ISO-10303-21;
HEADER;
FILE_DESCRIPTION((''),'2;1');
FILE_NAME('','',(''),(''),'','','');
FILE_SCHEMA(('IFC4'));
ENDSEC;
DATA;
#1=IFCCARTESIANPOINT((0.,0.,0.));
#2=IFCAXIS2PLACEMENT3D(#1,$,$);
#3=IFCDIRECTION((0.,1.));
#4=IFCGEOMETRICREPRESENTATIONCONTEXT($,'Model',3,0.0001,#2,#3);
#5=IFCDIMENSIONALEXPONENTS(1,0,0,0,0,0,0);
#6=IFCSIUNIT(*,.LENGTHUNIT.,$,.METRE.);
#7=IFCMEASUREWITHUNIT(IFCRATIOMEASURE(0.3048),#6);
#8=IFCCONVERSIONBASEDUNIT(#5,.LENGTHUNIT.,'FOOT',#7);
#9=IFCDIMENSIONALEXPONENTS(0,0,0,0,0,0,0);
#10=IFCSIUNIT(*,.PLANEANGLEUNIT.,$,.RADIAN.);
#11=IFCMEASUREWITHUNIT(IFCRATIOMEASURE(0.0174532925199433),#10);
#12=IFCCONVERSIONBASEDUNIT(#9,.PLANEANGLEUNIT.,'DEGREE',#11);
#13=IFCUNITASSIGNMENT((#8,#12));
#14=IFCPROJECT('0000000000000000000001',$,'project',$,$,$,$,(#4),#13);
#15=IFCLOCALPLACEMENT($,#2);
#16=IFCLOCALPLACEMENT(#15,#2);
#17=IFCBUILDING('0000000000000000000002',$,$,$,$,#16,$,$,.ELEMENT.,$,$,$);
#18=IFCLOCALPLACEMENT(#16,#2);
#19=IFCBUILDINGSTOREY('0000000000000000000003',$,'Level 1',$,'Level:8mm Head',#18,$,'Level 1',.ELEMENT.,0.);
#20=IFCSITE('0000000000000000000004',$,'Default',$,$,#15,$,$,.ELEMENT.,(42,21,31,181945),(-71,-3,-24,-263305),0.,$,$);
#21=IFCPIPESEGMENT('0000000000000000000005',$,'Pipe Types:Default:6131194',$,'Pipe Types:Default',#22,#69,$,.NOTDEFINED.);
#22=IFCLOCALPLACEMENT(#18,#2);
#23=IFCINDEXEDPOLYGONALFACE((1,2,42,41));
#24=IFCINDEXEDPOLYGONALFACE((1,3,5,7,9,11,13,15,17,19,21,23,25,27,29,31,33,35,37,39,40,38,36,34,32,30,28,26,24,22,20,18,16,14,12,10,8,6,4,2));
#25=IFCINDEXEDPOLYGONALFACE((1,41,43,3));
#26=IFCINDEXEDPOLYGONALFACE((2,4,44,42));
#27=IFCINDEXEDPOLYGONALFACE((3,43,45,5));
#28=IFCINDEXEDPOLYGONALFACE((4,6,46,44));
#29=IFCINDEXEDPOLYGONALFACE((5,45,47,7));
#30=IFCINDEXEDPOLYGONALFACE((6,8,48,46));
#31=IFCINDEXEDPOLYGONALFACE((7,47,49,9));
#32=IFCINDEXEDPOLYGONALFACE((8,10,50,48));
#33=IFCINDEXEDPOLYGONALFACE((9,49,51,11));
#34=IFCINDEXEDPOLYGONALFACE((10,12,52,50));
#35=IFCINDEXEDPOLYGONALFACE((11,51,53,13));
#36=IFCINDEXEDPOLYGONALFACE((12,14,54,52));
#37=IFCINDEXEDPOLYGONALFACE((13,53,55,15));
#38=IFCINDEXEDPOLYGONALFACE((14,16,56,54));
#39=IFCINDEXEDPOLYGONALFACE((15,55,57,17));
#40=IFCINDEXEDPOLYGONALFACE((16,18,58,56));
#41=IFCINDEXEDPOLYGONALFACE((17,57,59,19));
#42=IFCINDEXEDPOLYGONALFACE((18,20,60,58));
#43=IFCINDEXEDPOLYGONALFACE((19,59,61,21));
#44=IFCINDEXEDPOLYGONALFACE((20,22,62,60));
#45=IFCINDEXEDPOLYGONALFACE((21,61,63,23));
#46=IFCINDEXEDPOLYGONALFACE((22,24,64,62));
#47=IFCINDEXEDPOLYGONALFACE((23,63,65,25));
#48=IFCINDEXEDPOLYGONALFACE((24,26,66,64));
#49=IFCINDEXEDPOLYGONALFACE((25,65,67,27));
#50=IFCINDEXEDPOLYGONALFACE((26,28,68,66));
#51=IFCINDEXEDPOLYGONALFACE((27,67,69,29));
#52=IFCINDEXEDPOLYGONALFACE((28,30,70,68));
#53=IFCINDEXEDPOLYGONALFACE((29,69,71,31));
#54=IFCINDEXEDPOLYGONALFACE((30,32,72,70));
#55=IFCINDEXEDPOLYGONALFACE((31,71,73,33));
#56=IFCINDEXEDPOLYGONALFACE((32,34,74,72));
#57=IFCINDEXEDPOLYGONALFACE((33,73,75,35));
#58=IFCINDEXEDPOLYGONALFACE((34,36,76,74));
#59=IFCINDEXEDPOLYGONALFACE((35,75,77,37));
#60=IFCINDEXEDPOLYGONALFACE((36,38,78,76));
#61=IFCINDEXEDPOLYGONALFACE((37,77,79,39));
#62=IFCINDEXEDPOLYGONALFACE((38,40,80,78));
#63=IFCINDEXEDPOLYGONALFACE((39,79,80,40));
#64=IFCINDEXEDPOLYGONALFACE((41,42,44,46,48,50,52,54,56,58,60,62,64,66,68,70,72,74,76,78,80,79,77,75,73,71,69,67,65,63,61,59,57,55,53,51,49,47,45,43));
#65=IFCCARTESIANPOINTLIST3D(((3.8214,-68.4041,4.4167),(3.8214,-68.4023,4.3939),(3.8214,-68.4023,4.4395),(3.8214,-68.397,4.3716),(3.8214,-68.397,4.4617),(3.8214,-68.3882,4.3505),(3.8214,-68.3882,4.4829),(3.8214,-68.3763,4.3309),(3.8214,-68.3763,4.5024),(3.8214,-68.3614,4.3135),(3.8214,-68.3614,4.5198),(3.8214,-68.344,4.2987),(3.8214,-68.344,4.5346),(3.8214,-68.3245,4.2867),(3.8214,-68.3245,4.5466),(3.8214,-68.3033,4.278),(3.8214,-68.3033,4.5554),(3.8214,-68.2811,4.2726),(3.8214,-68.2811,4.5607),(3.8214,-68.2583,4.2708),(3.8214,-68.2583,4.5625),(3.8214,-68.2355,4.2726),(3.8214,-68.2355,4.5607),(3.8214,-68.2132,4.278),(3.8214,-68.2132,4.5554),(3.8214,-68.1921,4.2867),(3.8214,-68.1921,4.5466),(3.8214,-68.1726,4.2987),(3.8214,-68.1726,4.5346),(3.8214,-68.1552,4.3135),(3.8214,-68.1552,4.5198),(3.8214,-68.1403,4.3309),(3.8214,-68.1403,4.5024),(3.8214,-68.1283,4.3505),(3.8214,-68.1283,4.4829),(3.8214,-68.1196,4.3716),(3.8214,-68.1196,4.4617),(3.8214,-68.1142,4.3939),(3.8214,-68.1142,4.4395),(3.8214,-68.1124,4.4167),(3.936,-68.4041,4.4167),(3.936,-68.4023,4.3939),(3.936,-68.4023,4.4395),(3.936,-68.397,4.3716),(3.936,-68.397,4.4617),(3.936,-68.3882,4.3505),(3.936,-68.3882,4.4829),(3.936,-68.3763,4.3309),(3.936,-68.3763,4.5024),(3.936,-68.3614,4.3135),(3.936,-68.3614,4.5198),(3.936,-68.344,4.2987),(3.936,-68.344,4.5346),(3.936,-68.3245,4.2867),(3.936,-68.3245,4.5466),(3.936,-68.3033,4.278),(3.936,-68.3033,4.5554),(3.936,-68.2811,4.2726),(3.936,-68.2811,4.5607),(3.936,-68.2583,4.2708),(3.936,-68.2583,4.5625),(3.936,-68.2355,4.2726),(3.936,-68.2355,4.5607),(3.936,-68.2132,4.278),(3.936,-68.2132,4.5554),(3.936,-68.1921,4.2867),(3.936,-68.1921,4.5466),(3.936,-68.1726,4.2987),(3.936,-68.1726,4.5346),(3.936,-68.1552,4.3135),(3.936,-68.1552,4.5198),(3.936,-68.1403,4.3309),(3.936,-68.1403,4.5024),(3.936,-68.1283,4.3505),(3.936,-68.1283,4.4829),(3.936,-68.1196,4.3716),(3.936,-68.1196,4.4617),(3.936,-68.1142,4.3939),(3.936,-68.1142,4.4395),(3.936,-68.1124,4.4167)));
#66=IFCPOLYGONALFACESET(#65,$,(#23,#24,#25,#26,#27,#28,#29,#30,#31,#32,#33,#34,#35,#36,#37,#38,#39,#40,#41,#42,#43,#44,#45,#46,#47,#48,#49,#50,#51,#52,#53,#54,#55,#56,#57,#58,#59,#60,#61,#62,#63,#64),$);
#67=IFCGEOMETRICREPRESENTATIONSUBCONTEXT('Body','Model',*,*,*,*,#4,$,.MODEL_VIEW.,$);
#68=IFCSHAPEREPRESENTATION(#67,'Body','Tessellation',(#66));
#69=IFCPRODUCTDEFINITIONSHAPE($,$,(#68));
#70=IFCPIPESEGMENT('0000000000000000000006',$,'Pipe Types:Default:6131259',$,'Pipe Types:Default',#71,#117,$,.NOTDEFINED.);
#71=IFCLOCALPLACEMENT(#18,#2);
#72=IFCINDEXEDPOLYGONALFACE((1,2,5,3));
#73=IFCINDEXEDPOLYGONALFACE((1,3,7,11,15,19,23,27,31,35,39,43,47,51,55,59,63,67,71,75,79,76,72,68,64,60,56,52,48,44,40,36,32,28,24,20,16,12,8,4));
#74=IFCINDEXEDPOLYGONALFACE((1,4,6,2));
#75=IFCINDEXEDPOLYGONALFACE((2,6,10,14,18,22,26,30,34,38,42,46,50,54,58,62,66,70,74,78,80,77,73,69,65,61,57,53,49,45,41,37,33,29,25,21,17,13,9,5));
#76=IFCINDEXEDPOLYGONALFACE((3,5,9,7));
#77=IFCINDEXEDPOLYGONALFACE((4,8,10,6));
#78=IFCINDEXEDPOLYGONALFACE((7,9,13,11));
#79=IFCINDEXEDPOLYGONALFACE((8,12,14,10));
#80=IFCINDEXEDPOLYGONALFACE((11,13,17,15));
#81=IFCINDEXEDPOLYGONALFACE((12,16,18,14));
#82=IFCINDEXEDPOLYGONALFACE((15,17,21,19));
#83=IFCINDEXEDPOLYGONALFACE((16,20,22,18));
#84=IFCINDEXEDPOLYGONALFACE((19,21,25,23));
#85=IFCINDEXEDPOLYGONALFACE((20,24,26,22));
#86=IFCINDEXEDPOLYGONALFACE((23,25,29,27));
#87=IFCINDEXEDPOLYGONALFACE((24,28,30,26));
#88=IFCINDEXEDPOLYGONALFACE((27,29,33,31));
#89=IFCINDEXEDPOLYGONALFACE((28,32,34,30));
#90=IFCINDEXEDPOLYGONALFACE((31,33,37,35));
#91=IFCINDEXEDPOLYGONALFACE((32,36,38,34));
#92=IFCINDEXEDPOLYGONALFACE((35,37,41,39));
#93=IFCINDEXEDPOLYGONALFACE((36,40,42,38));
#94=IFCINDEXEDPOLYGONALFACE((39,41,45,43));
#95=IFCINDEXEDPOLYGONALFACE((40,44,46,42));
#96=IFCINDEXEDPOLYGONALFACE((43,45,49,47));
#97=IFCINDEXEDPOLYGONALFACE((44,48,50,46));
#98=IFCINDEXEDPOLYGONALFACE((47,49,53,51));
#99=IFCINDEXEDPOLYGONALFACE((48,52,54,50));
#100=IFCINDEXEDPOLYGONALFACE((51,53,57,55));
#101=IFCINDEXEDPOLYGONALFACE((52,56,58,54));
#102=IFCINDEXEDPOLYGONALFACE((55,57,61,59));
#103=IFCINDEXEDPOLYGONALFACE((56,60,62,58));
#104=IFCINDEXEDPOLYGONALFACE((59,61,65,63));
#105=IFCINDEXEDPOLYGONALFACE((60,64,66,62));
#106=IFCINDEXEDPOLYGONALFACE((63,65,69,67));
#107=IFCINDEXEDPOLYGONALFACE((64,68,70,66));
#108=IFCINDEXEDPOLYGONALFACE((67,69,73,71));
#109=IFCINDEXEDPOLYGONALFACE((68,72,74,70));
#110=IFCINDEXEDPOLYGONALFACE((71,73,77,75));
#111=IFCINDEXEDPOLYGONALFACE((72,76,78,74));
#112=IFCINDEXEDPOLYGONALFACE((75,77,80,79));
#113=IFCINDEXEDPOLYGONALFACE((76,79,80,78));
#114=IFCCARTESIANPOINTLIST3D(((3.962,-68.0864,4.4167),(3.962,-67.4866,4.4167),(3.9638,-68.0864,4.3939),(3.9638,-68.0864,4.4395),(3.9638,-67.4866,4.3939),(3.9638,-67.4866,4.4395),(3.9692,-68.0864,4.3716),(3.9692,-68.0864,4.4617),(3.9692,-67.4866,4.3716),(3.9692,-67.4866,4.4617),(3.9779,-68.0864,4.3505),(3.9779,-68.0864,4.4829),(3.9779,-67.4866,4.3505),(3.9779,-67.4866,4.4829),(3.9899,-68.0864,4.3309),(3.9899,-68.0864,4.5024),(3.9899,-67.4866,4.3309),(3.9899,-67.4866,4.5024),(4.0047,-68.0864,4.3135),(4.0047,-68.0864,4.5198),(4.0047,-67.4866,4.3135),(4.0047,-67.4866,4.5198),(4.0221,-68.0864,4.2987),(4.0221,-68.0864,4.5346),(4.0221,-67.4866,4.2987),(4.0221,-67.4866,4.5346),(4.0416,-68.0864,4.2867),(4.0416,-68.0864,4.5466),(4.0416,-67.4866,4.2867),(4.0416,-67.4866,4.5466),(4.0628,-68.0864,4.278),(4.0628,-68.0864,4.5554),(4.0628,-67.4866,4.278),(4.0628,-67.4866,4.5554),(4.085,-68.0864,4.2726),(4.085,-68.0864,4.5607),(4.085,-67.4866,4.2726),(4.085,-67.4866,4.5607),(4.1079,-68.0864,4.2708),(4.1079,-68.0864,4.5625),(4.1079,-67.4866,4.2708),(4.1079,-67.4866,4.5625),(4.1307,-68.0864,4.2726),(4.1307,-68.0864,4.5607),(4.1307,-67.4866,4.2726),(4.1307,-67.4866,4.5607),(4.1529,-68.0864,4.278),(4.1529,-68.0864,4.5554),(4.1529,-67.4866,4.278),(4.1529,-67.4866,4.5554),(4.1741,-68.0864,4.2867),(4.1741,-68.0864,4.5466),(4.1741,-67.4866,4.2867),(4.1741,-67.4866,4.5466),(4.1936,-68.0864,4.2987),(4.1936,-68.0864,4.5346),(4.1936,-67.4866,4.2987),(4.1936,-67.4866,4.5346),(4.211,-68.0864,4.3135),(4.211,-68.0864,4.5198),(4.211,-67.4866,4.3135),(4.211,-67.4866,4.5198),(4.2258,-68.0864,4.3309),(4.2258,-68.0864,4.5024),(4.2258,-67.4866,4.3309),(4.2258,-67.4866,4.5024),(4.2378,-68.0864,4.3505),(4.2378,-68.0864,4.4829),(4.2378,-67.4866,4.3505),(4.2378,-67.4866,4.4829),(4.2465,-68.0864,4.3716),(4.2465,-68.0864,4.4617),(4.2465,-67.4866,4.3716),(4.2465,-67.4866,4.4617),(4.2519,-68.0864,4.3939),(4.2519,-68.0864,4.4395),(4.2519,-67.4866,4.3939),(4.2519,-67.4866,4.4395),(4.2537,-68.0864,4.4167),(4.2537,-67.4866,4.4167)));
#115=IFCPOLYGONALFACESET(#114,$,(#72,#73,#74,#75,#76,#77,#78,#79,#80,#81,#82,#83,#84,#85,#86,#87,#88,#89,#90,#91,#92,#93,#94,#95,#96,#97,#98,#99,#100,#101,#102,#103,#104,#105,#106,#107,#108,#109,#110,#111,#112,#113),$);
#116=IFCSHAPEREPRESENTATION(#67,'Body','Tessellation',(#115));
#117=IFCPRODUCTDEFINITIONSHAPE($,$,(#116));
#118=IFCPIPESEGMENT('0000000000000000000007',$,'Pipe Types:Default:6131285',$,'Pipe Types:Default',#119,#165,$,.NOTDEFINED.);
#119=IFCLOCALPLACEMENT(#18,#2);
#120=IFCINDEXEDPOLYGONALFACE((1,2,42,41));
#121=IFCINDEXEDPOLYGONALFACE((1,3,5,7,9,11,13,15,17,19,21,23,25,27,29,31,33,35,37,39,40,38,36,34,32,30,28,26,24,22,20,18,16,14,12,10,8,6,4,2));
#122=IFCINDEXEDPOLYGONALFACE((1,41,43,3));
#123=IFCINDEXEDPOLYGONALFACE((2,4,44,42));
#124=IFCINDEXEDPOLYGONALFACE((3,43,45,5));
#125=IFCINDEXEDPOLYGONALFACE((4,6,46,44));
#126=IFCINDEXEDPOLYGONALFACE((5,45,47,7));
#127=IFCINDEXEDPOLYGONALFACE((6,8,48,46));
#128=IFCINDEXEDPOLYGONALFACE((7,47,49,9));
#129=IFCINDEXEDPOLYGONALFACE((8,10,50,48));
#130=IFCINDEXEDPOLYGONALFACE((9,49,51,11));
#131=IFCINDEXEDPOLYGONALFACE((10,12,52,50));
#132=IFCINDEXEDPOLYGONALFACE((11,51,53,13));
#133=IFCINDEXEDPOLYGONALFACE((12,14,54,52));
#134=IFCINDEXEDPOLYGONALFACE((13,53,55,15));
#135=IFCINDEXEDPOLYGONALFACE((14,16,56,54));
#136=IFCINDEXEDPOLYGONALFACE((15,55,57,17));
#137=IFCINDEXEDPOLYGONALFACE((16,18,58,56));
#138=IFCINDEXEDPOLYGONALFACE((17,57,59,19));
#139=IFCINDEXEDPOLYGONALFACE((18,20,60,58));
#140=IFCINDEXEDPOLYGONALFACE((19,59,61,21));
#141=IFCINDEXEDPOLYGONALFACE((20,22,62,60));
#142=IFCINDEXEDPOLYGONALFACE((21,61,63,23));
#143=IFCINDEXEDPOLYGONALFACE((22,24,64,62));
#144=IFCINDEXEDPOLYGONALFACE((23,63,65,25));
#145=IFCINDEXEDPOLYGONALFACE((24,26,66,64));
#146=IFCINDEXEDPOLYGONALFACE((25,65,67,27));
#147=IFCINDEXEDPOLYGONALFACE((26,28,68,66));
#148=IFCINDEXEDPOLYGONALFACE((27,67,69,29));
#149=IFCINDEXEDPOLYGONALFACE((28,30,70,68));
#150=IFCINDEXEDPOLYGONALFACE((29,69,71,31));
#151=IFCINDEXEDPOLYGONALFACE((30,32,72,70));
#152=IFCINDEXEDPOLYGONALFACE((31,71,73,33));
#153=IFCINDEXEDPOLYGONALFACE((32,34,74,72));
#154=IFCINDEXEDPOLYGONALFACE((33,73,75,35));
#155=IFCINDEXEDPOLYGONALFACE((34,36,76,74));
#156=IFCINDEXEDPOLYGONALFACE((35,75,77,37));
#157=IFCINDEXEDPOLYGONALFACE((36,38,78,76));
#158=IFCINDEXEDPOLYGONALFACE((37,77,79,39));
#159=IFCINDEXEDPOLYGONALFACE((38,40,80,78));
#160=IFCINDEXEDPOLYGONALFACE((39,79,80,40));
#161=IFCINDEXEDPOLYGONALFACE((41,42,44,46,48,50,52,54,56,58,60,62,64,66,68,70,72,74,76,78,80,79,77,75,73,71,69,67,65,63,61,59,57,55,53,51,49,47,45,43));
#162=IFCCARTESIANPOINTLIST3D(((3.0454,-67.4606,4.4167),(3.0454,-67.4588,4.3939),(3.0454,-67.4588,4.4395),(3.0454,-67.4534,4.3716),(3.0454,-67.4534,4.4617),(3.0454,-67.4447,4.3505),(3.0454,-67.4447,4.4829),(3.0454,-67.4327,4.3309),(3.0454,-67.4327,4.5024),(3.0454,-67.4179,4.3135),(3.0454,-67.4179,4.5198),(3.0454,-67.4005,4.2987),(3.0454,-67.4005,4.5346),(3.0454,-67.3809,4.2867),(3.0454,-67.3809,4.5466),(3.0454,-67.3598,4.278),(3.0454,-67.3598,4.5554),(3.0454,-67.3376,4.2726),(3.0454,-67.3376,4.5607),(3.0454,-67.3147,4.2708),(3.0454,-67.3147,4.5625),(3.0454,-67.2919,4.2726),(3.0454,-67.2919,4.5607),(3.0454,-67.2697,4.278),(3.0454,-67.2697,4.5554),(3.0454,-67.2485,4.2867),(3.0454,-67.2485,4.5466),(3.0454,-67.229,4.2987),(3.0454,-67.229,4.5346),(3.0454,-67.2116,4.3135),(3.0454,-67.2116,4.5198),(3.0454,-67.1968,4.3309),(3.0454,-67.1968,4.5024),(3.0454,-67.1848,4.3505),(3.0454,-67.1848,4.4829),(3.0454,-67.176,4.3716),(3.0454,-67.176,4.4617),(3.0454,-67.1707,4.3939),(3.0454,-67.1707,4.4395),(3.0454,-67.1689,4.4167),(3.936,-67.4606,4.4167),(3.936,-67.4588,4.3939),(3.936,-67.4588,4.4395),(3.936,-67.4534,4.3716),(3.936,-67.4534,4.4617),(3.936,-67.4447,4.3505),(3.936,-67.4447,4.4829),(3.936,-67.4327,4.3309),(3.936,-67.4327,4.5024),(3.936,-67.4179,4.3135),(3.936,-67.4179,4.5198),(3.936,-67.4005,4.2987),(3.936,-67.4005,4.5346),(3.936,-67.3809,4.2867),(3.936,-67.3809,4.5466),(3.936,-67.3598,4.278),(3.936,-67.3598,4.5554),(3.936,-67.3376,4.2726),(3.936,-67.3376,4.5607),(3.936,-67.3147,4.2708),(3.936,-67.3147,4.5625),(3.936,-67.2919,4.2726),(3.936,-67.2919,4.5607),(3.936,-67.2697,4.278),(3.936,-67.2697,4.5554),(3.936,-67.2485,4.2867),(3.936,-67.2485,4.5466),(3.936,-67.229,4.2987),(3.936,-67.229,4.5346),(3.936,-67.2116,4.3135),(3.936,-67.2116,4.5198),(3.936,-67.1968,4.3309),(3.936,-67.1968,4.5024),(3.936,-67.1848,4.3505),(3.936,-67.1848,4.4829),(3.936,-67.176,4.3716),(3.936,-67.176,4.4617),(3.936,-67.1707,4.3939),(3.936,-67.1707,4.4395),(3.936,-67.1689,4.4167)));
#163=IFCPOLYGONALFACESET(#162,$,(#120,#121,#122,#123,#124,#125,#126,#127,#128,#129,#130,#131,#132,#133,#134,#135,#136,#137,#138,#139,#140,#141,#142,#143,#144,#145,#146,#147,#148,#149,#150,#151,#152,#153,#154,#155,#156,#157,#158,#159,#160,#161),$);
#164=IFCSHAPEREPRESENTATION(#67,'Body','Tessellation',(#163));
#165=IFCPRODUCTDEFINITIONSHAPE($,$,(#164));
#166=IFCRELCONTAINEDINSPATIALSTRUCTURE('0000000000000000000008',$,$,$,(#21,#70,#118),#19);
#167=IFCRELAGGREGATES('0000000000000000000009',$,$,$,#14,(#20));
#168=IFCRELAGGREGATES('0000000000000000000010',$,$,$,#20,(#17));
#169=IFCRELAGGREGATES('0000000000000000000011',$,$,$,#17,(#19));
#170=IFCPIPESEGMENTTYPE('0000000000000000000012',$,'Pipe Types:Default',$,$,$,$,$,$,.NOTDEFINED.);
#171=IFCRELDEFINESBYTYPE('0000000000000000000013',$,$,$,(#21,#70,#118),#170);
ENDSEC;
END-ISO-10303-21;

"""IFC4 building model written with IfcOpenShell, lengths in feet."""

from ifc_helpers import new_model, entity, si_unit, converted_unit, direction, frame, origin, place, context, subcontext, project, spatial, indexed_curve, outline, extrude, type_object, element, save


model = new_model("IFC4")

# Units and contexts
model_context = context("Model", 3, precision=0.0001, world=origin(), true_north=direction((0.0, 1.0)))
body_context = subcontext(model_context, "Body", "Model", "MODEL_VIEW")
ifc_project = project(units=[converted_unit("LENGTHUNIT", "FOOT", entity("IfcRatioMeasure", 0.3048), si_unit("LENGTHUNIT", "METRE"), dimensions=[1, 0, 0, 0, 0, 0, 0]), converted_unit("PLANEANGLEUNIT", "DEGREE", entity("IfcRatioMeasure", 0.0174532925199433), si_unit("PLANEANGLEUNIT", "RADIAN"), dimensions=[0, 0, 0, 0, 0, 0, 0])], contexts=[model_context])

# Site, building, storey
site_placement = place(None, origin())
site = spatial("IfcSite", under=ifc_project, at=site_placement, Name="Default", CompositionType="ELEMENT", RefLatitude=(42, 21, 31, 181945), RefLongitude=(-71, -3, -24, -263305), RefElevation=0.0)
building_placement = place(site_placement, origin())
building = spatial("IfcBuilding", under=site, at=building_placement, CompositionType="ELEMENT")
storey_placement = place(building_placement, origin())
storey = spatial("IfcBuildingStorey", under=building, at=storey_placement, Name="Level 1", ObjectType="Level:8mm Head", LongName="Level 1", CompositionType="ELEMENT", Elevation=0.0)

# Pipe segments
pipe_segment_type = type_object("IfcPipeSegmentType", Name="Pipe Types:Default", PredefinedType="NOTDEFINED")
pipe_segment_1_placement = place(storey_placement, origin())
element("IfcPipeSegment", 1, at=pipe_segment_1_placement, inside=storey, type_object=pipe_segment_type, Name="Pipe Types:Default:6131194", ObjectType="Pipe Types:Default", PredefinedType="NOTDEFINED", context=body_context, shape_type="SweptSolid", body=[
    extrude(outline(indexed_curve([(0.1458, 0.0), (0.144, 0.0228), (0.1387, 0.0451), (0.1299, 0.0662), (0.118, 0.0857), (0.1031, 0.1031), (0.0857, 0.118), (0.0662, 0.1299), (0.0451, 0.1387), (0.0228, 0.144), (0.0, 0.1458), (-0.0228, 0.144), (-0.0451, 0.1387), (-0.0662, 0.1299), (-0.0857, 0.118), (-0.1031, 0.1031), (-0.118, 0.0857), (-0.1299, 0.0662), (-0.1387, 0.0451), (-0.144, 0.0228), (-0.1458, 0.0), (-0.144, -0.0228), (-0.1387, -0.0451), (-0.1299, -0.0662), (-0.118, -0.0857), (-0.1031, -0.1031), (-0.0857, -0.118), (-0.0662, -0.1299), (-0.0451, -0.1387), (-0.0228, -0.144), (0.0, -0.1458), (0.0228, -0.144), (0.0451, -0.1387), (0.0662, -0.1299), (0.0857, -0.118), (0.1031, -0.1031), (0.118, -0.0857), (0.1299, -0.0662), (0.1387, -0.0451), (0.144, -0.0228), (0.1458, 0.0)], self_intersect=False)), frame((3.8214, -68.2583, 4.4167), z_axis=(1.0, 0.0, 0.0), x_axis=(0.0, -1.0, 0.0)), (0.0, 0.0, 1.0), 0.1146),
])
pipe_segment_2_placement = place(storey_placement, origin())
element("IfcPipeSegment", 2, at=pipe_segment_2_placement, inside=storey, type_object=pipe_segment_type, Name="Pipe Types:Default:6131259", ObjectType="Pipe Types:Default", PredefinedType="NOTDEFINED", context=body_context, shape_type="SweptSolid", body=[
    extrude(outline(indexed_curve([(0.1458, 0.0), (0.144, 0.0228), (0.1387, 0.0451), (0.1299, 0.0662), (0.118, 0.0857), (0.1031, 0.1031), (0.0857, 0.118), (0.0662, 0.1299), (0.0451, 0.1387), (0.0228, 0.144), (0.0, 0.1458), (-0.0228, 0.144), (-0.0451, 0.1387), (-0.0662, 0.1299), (-0.0857, 0.118), (-0.1031, 0.1031), (-0.118, 0.0857), (-0.1299, 0.0662), (-0.1387, 0.0451), (-0.144, 0.0228), (-0.1458, 0.0), (-0.144, -0.0228), (-0.1387, -0.0451), (-0.1299, -0.0662), (-0.118, -0.0857), (-0.1031, -0.1031), (-0.0857, -0.118), (-0.0662, -0.1299), (-0.0451, -0.1387), (-0.0228, -0.144), (0.0, -0.1458), (0.0228, -0.144), (0.0451, -0.1387), (0.0662, -0.1299), (0.0857, -0.118), (0.1031, -0.1031), (0.118, -0.0857), (0.1299, -0.0662), (0.1387, -0.0451), (0.144, -0.0228), (0.1458, 0.0)], self_intersect=False)), frame((4.1079, -68.0864, 4.4167), z_axis=(0.0, 1.0, 0.0), x_axis=(1.0, 0.0, 0.0)), (0.0, 0.0, 1.0), 0.5998),
])
pipe_segment_3_placement = place(storey_placement, origin())
element("IfcPipeSegment", 3, at=pipe_segment_3_placement, inside=storey, type_object=pipe_segment_type, Name="Pipe Types:Default:6131285", ObjectType="Pipe Types:Default", PredefinedType="NOTDEFINED", context=body_context, shape_type="SweptSolid", body=[
    extrude(outline(indexed_curve([(0.1458, 0.0), (0.144, 0.0228), (0.1387, 0.0451), (0.1299, 0.0662), (0.118, 0.0857), (0.1031, 0.1031), (0.0857, 0.118), (0.0662, 0.1299), (0.0451, 0.1387), (0.0228, 0.144), (0.0, 0.1458), (-0.0228, 0.144), (-0.0451, 0.1387), (-0.0662, 0.1299), (-0.0857, 0.118), (-0.1031, 0.1031), (-0.118, 0.0857), (-0.1299, 0.0662), (-0.1387, 0.0451), (-0.144, 0.0228), (-0.1458, 0.0), (-0.144, -0.0228), (-0.1387, -0.0451), (-0.1299, -0.0662), (-0.118, -0.0857), (-0.1031, -0.1031), (-0.0857, -0.118), (-0.0662, -0.1299), (-0.0451, -0.1387), (-0.0228, -0.144), (0.0, -0.1458), (0.0228, -0.144), (0.0451, -0.1387), (0.0662, -0.1299), (0.0857, -0.118), (0.1031, -0.1031), (0.118, -0.0857), (0.1299, -0.0662), (0.1387, -0.0451), (0.144, -0.0228), (0.1458, 0.0)], self_intersect=False)), frame((3.0454, -67.3147, 4.4167), z_axis=(1.0, 0.0, 0.0), x_axis=(0.0, 1.0, 0.0)), (0.0, 0.0, 1.0), 0.8906),
])

save(model, "model.ifc")
